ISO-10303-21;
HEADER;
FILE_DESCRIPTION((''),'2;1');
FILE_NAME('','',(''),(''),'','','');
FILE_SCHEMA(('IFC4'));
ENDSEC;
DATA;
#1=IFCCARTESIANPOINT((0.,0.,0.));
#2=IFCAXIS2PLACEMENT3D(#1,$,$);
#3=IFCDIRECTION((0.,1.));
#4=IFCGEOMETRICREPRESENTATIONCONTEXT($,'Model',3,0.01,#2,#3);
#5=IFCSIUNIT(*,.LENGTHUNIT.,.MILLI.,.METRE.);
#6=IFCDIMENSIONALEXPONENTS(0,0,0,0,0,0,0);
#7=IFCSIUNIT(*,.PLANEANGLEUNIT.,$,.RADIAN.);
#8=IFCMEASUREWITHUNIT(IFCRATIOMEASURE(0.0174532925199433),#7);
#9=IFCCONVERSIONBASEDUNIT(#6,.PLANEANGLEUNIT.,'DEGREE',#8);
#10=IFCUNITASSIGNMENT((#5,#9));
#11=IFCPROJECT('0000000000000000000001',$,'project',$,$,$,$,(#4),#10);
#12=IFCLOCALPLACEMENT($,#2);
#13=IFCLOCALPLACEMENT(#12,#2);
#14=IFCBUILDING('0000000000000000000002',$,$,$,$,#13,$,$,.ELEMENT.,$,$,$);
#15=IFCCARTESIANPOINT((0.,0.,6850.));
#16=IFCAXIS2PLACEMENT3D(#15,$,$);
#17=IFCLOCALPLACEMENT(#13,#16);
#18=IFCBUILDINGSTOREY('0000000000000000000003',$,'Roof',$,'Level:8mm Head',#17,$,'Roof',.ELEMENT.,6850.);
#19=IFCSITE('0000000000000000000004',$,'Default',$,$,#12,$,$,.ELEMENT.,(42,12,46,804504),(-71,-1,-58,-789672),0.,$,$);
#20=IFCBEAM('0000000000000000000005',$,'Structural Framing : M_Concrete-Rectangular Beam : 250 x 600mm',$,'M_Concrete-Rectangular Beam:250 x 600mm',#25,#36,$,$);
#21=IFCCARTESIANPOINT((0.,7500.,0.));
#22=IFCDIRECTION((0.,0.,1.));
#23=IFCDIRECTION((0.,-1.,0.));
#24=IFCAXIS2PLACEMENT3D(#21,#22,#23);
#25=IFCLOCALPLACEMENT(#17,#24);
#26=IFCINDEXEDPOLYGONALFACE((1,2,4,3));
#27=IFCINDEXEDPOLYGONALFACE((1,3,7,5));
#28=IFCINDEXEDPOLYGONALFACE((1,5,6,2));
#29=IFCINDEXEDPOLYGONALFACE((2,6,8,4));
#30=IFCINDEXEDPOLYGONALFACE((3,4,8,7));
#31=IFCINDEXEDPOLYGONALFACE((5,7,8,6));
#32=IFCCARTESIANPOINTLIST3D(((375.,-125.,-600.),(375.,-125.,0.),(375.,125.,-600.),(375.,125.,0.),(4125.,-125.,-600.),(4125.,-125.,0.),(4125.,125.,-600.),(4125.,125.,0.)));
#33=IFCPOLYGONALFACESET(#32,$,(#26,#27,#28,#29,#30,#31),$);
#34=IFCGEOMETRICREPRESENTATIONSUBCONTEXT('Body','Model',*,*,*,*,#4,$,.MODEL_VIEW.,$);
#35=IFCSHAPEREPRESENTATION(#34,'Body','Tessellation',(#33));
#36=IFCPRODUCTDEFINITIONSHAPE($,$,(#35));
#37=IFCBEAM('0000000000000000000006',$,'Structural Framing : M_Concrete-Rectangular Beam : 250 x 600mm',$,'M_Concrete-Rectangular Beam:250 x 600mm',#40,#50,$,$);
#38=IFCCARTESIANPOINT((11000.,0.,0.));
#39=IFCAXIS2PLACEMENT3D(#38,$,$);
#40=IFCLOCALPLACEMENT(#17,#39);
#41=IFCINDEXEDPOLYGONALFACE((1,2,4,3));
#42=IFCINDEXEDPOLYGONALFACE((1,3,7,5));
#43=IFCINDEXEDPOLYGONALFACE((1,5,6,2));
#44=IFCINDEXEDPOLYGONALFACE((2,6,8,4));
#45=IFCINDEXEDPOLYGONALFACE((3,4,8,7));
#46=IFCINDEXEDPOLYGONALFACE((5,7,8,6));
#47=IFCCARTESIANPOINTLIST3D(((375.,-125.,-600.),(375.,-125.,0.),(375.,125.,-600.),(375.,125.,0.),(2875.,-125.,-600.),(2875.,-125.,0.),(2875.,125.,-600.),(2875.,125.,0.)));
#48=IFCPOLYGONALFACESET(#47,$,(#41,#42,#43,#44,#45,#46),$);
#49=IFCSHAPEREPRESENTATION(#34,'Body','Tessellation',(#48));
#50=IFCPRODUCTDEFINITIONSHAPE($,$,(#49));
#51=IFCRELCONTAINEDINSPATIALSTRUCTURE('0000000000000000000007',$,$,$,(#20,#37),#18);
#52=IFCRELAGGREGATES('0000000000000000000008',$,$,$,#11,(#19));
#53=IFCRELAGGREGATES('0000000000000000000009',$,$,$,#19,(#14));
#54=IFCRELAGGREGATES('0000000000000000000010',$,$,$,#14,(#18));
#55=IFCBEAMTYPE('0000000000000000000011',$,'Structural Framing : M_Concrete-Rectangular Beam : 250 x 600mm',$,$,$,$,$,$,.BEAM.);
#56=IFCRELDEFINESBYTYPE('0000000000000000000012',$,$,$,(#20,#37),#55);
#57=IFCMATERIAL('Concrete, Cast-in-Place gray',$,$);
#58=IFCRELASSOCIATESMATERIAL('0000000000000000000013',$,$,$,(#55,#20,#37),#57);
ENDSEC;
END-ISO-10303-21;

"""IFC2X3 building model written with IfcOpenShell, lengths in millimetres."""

from ifc_helpers import new_model, entity, si_unit, converted_unit, direction, frame, frame_2d, origin, origin_2d_with_axis, place, context, subcontext, project, spatial, rectangle, extrude, material, type_object, element, save


model = new_model("IFC2X3")

# Units and contexts
model_context = context("Model", 3, precision=0.01, world=origin(), true_north=direction((0.0, 1.0)))
body_context = subcontext(model_context, "Body", "Model", "MODEL_VIEW")
ifc_project = project(units=[si_unit("LENGTHUNIT", "METRE", prefix="MILLI"), converted_unit("PLANEANGLEUNIT", "DEGREE", entity("IfcRatioMeasure", 0.0174532925199433), si_unit("PLANEANGLEUNIT", "RADIAN"), dimensions=[0, 0, 0, 0, 0, 0, 0])], contexts=[model_context])

# Site, building, storey
site_placement = place(None, origin())
site = spatial("IfcSite", under=ifc_project, at=site_placement, Name="Default", CompositionType="ELEMENT", RefLatitude=(42, 12, 46, 804504), RefLongitude=(-71, -1, -58, -789672), RefElevation=0.0)
building_placement = place(site_placement, origin())
building = spatial("IfcBuilding", under=site, at=building_placement, CompositionType="ELEMENT")
storey_placement = place(building_placement, frame((0.0, 0.0, 6850.0)))
storey = spatial("IfcBuildingStorey", under=building, at=storey_placement, Name="Roof", ObjectType="Level:8mm Head", LongName="Roof", CompositionType="ELEMENT", Elevation=6850.0)

# Beams
ifc_material = material(Name="Concrete, Cast-in-Place gray")
beam_type_1 = type_object("IfcBeamType", Name="Structural Framing : M_Concrete-Rectangular Beam : 250 x 600mm", PredefinedType="BEAM", material=ifc_material)
beam_1_placement = place(storey_placement, frame((0.0, 7500.0, 0.0), z_axis=(0.0, 0.0, 1.0), x_axis=(0.0, -1.0, 0.0)))
element("IfcBeam", 1, at=beam_1_placement, inside=storey, type_object=beam_type_1, material=ifc_material, Name="Structural Framing : M_Concrete-Rectangular Beam : 250 x 600mm", ObjectType="M_Concrete-Rectangular Beam:250 x 600mm", context=body_context, shape_type="SweptSolid", body=[
    extrude(rectangle(XDim=600.0, YDim=250.0, at=origin_2d_with_axis()), frame((375.0, 0.0, -300.0), z_axis=(1.0, 0.0, 0.0), x_axis=(0.0, 0.0, -1.0)), (0.0, 0.0, 1.0), 3750.0),
])
beam_2_placement = place(storey_placement, frame((11000.0, 0.0, 0.0)))
element("IfcBeam", 2, at=beam_2_placement, inside=storey, type_object=beam_type_1, material=ifc_material, Name="Structural Framing : M_Concrete-Rectangular Beam : 250 x 600mm", ObjectType="M_Concrete-Rectangular Beam:250 x 600mm", context=body_context, shape_type="SweptSolid", body=[
    extrude(rectangle(XDim=600.0, YDim=250.0, at=frame_2d((0.0, 0.0), x_axis=(1.0, 0.0))), frame((375.0, 0.0, -300.0), z_axis=(1.0, 0.0, 0.0), x_axis=(0.0, 0.0, -1.0)), (0.0, 0.0, 1.0), 2500.0),
])

save(model, "model.ifc")
